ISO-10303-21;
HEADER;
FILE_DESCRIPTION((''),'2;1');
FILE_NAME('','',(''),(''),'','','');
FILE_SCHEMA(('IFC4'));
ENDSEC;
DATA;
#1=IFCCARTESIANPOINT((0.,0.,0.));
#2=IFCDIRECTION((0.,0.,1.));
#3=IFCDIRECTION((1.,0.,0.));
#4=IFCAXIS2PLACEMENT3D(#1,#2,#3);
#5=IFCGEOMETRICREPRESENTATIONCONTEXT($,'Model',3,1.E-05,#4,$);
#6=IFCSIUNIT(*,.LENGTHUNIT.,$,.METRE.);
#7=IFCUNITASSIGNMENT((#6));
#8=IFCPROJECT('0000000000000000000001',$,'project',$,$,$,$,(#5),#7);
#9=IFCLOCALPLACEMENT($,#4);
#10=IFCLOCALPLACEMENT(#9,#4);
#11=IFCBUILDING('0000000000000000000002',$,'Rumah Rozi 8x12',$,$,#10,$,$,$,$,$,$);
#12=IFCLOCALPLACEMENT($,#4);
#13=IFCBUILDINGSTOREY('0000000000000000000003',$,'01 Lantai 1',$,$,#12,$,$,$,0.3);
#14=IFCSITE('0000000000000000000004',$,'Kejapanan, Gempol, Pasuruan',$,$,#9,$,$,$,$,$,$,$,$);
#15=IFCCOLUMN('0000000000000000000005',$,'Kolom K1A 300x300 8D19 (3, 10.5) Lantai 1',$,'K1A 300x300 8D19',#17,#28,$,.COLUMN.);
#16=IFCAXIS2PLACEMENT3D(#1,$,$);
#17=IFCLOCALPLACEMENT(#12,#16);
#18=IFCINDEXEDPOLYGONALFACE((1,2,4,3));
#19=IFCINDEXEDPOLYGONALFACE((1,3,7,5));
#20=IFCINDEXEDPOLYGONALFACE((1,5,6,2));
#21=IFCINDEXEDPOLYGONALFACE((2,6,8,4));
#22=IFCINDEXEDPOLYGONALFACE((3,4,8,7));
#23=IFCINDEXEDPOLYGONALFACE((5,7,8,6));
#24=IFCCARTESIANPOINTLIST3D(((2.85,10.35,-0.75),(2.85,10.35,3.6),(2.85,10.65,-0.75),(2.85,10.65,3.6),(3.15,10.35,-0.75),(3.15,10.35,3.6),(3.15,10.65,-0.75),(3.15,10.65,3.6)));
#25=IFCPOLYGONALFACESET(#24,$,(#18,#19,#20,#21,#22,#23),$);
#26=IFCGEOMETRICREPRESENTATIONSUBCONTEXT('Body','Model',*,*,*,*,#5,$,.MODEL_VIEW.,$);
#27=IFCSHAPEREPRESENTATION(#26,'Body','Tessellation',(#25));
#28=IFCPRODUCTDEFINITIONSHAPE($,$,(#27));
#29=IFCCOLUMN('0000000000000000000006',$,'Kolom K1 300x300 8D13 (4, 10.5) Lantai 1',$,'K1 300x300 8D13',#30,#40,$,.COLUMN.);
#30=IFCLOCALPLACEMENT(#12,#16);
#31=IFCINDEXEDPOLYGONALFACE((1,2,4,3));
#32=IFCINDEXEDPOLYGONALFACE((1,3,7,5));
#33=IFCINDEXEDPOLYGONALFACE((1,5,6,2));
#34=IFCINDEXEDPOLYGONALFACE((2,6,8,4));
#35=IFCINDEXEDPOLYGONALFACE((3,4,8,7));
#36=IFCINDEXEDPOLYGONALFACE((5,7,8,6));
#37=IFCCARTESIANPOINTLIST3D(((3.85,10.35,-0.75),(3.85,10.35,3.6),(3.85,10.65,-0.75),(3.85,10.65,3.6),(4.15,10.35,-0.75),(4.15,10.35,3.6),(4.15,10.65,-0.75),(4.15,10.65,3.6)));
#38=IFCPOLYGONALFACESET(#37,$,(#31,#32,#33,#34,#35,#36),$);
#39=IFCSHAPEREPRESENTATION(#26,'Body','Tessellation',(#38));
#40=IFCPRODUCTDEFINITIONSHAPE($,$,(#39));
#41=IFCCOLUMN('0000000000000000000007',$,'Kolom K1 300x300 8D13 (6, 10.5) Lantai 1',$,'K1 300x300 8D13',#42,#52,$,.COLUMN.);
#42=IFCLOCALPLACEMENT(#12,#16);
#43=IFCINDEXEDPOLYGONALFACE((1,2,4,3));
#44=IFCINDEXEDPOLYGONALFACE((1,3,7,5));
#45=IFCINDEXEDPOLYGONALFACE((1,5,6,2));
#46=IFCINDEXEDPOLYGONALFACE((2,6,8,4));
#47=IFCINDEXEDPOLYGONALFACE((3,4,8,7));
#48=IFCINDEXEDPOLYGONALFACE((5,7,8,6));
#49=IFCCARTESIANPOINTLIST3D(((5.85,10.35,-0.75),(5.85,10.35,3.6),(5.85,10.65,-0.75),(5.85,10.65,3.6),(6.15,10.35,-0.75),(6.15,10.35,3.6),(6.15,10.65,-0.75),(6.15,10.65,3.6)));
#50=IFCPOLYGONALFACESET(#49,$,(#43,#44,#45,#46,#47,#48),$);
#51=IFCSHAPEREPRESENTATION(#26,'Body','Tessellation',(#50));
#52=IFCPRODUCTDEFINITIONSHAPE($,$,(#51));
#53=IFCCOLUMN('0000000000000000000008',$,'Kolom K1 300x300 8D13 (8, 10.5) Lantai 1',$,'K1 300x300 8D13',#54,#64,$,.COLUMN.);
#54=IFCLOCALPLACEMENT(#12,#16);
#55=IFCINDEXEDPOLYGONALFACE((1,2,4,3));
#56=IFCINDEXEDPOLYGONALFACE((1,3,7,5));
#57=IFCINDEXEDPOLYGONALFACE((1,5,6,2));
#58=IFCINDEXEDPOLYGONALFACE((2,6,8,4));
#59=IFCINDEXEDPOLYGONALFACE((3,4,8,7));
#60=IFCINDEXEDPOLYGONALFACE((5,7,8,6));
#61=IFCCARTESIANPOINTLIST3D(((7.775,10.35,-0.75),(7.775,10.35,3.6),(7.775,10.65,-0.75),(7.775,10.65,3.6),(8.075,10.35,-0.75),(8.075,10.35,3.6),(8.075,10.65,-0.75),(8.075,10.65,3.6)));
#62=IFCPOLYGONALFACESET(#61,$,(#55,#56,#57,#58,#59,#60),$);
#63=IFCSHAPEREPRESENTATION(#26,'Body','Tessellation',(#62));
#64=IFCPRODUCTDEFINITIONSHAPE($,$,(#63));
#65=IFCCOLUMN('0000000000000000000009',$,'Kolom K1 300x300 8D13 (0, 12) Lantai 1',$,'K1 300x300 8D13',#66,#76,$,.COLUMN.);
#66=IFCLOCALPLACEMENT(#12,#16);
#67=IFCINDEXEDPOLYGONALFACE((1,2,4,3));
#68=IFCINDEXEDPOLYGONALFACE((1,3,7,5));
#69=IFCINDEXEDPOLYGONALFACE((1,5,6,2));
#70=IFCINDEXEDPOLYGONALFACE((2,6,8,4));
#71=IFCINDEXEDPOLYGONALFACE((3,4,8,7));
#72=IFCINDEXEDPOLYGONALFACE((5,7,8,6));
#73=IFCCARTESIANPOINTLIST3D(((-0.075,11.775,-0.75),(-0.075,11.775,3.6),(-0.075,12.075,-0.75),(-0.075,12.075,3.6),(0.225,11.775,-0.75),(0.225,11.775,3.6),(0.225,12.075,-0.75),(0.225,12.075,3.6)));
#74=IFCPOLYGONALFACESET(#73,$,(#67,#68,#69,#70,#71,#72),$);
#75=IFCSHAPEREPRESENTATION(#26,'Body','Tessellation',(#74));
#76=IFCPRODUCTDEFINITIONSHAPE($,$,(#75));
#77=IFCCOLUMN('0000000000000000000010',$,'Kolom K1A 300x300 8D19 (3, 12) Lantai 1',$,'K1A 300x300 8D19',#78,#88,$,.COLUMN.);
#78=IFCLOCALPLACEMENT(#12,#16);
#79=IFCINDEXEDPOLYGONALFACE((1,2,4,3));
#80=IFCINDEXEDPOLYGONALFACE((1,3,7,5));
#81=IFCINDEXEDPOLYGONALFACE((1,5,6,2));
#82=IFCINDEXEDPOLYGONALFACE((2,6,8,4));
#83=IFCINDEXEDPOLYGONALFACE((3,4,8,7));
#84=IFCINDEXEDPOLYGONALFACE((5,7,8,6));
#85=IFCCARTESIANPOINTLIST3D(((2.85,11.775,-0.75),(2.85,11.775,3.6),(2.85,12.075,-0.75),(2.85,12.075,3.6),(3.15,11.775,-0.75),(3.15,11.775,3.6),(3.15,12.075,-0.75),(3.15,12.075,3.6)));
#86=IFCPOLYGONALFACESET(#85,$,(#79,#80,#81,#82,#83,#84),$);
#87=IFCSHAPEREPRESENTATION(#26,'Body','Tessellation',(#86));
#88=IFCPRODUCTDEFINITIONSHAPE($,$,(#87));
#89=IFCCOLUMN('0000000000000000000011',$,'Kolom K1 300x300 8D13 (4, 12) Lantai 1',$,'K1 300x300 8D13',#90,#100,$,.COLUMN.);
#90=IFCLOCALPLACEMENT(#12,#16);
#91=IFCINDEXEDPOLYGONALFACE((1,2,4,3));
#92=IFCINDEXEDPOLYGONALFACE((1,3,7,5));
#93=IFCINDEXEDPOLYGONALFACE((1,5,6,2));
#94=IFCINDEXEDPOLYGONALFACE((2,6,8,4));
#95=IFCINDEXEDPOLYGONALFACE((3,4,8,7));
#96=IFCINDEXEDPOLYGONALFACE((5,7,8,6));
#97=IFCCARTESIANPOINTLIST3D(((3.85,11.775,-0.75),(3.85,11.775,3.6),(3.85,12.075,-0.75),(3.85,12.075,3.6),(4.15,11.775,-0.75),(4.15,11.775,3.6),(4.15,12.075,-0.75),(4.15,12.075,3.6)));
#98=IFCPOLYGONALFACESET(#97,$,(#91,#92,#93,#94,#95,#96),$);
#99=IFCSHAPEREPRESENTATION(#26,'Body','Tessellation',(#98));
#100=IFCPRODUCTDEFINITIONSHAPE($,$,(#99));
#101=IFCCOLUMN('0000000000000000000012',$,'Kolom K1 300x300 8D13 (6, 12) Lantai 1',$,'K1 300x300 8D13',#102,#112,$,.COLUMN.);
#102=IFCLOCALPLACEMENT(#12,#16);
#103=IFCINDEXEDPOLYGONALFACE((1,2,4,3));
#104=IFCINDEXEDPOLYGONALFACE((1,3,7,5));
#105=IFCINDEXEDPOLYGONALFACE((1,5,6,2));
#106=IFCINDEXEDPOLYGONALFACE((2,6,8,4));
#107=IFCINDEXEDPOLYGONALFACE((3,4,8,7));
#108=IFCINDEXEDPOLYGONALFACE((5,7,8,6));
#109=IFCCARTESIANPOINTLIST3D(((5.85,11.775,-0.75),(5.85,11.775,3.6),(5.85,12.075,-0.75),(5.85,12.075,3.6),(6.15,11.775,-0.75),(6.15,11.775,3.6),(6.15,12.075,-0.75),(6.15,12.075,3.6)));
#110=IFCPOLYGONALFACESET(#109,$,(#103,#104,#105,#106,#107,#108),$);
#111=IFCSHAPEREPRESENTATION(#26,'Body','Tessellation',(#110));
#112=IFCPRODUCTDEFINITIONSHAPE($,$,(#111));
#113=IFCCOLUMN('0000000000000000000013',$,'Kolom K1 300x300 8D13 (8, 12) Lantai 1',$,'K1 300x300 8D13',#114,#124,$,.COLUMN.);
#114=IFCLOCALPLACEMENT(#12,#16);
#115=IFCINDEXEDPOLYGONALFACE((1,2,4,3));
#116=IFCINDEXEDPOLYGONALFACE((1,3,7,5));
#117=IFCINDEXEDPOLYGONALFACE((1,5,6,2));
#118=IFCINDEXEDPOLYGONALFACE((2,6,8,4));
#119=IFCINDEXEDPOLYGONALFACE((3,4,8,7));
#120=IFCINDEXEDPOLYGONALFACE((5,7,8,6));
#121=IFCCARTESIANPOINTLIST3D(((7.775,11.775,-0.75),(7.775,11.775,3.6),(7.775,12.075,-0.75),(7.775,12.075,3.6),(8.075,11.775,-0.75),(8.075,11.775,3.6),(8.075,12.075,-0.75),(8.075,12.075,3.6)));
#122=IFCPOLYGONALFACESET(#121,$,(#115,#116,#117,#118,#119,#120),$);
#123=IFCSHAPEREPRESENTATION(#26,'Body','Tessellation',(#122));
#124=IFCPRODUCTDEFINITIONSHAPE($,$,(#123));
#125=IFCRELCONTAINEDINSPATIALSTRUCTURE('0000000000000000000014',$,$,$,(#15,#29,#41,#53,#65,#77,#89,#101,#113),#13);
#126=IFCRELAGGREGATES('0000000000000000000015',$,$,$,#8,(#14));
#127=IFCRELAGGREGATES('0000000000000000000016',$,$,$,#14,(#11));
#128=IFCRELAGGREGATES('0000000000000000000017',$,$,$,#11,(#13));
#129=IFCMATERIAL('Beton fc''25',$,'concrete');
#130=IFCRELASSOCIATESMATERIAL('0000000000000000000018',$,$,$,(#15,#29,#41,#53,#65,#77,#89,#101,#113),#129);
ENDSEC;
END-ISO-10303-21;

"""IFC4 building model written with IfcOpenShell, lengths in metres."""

from ifc_helpers import new_model, si_unit, frame, origin_with_axes, place, context, subcontext, project, spatial, line, indexed_curve, outline, extrude, material, element, save


model = new_model("IFC4")

# Units and contexts
model_context = context("Model", 3, precision=1e-05, world=origin_with_axes())
body_context = subcontext(model_context, "Body", "Model", "MODEL_VIEW")
ifc_project = project(units=[si_unit("LENGTHUNIT", "METRE")], contexts=[model_context])

# Site, building, storey
site_placement = place(None, origin_with_axes())
site = spatial("IfcSite", under=ifc_project, at=site_placement, Name="Kejapanan, Gempol, Pasuruan")
building_placement = place(site_placement, origin_with_axes())
building = spatial("IfcBuilding", under=site, at=building_placement, Name="Rumah Rozi 8x12")
storey_placement = place(None, origin_with_axes())
storey = spatial("IfcBuildingStorey", under=building, at=storey_placement, Name="01 Lantai 1", Elevation=0.3)

# Columns
ifc_material_1 = material(Name="Beton fc'25", Category="concrete")
column_1_placement = place(storey_placement, origin_with_axes())
element("IfcColumn", 1, at=column_1_placement, inside=storey, material=ifc_material_1, Name="Kolom K1A 300x300 8D19 (3, 10.5) Lantai 1", ObjectType="K1A 300x300 8D19", PredefinedType="COLUMN", context=body_context, shape_type="SweptSolid", body=[
    extrude(outline(indexed_curve([(2.85, 10.35), (3.15, 10.35), (3.15, 10.65), (2.85, 10.65)], segments=[line(1, 2, 3, 4, 1)])), frame((0.0, 0.0, -0.75), z_axis=(0.0, 0.0, 1.0), x_axis=(1.0, 0.0, 0.0)), (0.0, 0.0, 1.0), 4.35),
])
column_2_placement = place(storey_placement, origin_with_axes())
element("IfcColumn", 2, at=column_2_placement, inside=storey, material=ifc_material_1, Name="Kolom K1 300x300 8D13 (4, 10.5) Lantai 1", ObjectType="K1 300x300 8D13", PredefinedType="COLUMN", context=body_context, shape_type="SweptSolid", body=[
    extrude(outline(indexed_curve([(3.85, 10.35), (4.15, 10.35), (4.15, 10.65), (3.85, 10.65)], segments=[line(1, 2, 3, 4, 1)])), frame((0.0, 0.0, -0.75), z_axis=(0.0, 0.0, 1.0), x_axis=(1.0, 0.0, 0.0)), (0.0, 0.0, 1.0), 4.35),
])
column_3_placement = place(storey_placement, origin_with_axes())
element("IfcColumn", 3, at=column_3_placement, inside=storey, material=ifc_material_1, Name="Kolom K1 300x300 8D13 (6, 10.5) Lantai 1", ObjectType="K1 300x300 8D13", PredefinedType="COLUMN", context=body_context, shape_type="SweptSolid", body=[
    extrude(outline(indexed_curve([(5.85, 10.35), (6.15, 10.35), (6.15, 10.65), (5.85, 10.65)], segments=[line(1, 2, 3, 4, 1)])), frame((0.0, 0.0, -0.75), z_axis=(0.0, 0.0, 1.0), x_axis=(1.0, 0.0, 0.0)), (0.0, 0.0, 1.0), 4.35),
])
column_4_placement = place(storey_placement, origin_with_axes())
element("IfcColumn", 4, at=column_4_placement, inside=storey, material=ifc_material_1, Name="Kolom K1 300x300 8D13 (8, 10.5) Lantai 1", ObjectType="K1 300x300 8D13", PredefinedType="COLUMN", context=body_context, shape_type="SweptSolid", body=[
    extrude(outline(indexed_curve([(7.775, 10.35), (8.075, 10.35), (8.075, 10.65), (7.775, 10.65)], segments=[line(1, 2, 3, 4, 1)])), frame((0.0, 0.0, -0.75), z_axis=(0.0, 0.0, 1.0), x_axis=(1.0, 0.0, 0.0)), (0.0, 0.0, 1.0), 4.35),
])
column_5_placement = place(storey_placement, origin_with_axes())
element("IfcColumn", 5, at=column_5_placement, inside=storey, material=ifc_material_1, Name="Kolom K1 300x300 8D13 (0, 12) Lantai 1", ObjectType="K1 300x300 8D13", PredefinedType="COLUMN", context=body_context, shape_type="SweptSolid", body=[
    extrude(outline(indexed_curve([(-0.075, 11.775), (0.225, 11.775), (0.225, 12.075), (-0.075, 12.075)], segments=[line(1, 2, 3, 4, 1)])), frame((0.0, 0.0, -0.75), z_axis=(0.0, 0.0, 1.0), x_axis=(1.0, 0.0, 0.0)), (0.0, 0.0, 1.0), 4.35),
])
column_6_placement = place(storey_placement, origin_with_axes())
element("IfcColumn", 6, at=column_6_placement, inside=storey, material=ifc_material_1, Name="Kolom K1A 300x300 8D19 (3, 12) Lantai 1", ObjectType="K1A 300x300 8D19", PredefinedType="COLUMN", context=body_context, shape_type="SweptSolid", body=[
    extrude(outline(indexed_curve([(2.85, 11.775), (3.15, 11.775), (3.15, 12.075), (2.85, 12.075)], segments=[line(1, 2, 3, 4, 1)])), frame((0.0, 0.0, -0.75), z_axis=(0.0, 0.0, 1.0), x_axis=(1.0, 0.0, 0.0)), (0.0, 0.0, 1.0), 4.35),
])
column_7_placement = place(storey_placement, origin_with_axes())
element("IfcColumn", 7, at=column_7_placement, inside=storey, material=ifc_material_1, Name="Kolom K1 300x300 8D13 (4, 12) Lantai 1", ObjectType="K1 300x300 8D13", PredefinedType="COLUMN", context=body_context, shape_type="SweptSolid", body=[
    extrude(outline(indexed_curve([(3.85, 11.775), (4.15, 11.775), (4.15, 12.075), (3.85, 12.075)], segments=[line(1, 2, 3, 4, 1)])), frame((0.0, 0.0, -0.75), z_axis=(0.0, 0.0, 1.0), x_axis=(1.0, 0.0, 0.0)), (0.0, 0.0, 1.0), 4.35),
])
column_8_placement = place(storey_placement, origin_with_axes())
element("IfcColumn", 8, at=column_8_placement, inside=storey, material=ifc_material_1, Name="Kolom K1 300x300 8D13 (6, 12) Lantai 1", ObjectType="K1 300x300 8D13", PredefinedType="COLUMN", context=body_context, shape_type="SweptSolid", body=[
    extrude(outline(indexed_curve([(5.85, 11.775), (6.15, 11.775), (6.15, 12.075), (5.85, 12.075)], segments=[line(1, 2, 3, 4, 1)])), frame((0.0, 0.0, -0.75), z_axis=(0.0, 0.0, 1.0), x_axis=(1.0, 0.0, 0.0)), (0.0, 0.0, 1.0), 4.35),
])
column_9_placement = place(storey_placement, origin_with_axes())
element("IfcColumn", 9, at=column_9_placement, inside=storey, material=ifc_material_1, Name="Kolom K1 300x300 8D13 (8, 12) Lantai 1", ObjectType="K1 300x300 8D13", PredefinedType="COLUMN", context=body_context, shape_type="SweptSolid", body=[
    extrude(outline(indexed_curve([(7.775, 11.775), (8.075, 11.775), (8.075, 12.075), (7.775, 12.075)], segments=[line(1, 2, 3, 4, 1)])), frame((0.0, 0.0, -0.75), z_axis=(0.0, 0.0, 1.0), x_axis=(1.0, 0.0, 0.0)), (0.0, 0.0, 1.0), 4.35),
])

save(model, "model.ifc")
